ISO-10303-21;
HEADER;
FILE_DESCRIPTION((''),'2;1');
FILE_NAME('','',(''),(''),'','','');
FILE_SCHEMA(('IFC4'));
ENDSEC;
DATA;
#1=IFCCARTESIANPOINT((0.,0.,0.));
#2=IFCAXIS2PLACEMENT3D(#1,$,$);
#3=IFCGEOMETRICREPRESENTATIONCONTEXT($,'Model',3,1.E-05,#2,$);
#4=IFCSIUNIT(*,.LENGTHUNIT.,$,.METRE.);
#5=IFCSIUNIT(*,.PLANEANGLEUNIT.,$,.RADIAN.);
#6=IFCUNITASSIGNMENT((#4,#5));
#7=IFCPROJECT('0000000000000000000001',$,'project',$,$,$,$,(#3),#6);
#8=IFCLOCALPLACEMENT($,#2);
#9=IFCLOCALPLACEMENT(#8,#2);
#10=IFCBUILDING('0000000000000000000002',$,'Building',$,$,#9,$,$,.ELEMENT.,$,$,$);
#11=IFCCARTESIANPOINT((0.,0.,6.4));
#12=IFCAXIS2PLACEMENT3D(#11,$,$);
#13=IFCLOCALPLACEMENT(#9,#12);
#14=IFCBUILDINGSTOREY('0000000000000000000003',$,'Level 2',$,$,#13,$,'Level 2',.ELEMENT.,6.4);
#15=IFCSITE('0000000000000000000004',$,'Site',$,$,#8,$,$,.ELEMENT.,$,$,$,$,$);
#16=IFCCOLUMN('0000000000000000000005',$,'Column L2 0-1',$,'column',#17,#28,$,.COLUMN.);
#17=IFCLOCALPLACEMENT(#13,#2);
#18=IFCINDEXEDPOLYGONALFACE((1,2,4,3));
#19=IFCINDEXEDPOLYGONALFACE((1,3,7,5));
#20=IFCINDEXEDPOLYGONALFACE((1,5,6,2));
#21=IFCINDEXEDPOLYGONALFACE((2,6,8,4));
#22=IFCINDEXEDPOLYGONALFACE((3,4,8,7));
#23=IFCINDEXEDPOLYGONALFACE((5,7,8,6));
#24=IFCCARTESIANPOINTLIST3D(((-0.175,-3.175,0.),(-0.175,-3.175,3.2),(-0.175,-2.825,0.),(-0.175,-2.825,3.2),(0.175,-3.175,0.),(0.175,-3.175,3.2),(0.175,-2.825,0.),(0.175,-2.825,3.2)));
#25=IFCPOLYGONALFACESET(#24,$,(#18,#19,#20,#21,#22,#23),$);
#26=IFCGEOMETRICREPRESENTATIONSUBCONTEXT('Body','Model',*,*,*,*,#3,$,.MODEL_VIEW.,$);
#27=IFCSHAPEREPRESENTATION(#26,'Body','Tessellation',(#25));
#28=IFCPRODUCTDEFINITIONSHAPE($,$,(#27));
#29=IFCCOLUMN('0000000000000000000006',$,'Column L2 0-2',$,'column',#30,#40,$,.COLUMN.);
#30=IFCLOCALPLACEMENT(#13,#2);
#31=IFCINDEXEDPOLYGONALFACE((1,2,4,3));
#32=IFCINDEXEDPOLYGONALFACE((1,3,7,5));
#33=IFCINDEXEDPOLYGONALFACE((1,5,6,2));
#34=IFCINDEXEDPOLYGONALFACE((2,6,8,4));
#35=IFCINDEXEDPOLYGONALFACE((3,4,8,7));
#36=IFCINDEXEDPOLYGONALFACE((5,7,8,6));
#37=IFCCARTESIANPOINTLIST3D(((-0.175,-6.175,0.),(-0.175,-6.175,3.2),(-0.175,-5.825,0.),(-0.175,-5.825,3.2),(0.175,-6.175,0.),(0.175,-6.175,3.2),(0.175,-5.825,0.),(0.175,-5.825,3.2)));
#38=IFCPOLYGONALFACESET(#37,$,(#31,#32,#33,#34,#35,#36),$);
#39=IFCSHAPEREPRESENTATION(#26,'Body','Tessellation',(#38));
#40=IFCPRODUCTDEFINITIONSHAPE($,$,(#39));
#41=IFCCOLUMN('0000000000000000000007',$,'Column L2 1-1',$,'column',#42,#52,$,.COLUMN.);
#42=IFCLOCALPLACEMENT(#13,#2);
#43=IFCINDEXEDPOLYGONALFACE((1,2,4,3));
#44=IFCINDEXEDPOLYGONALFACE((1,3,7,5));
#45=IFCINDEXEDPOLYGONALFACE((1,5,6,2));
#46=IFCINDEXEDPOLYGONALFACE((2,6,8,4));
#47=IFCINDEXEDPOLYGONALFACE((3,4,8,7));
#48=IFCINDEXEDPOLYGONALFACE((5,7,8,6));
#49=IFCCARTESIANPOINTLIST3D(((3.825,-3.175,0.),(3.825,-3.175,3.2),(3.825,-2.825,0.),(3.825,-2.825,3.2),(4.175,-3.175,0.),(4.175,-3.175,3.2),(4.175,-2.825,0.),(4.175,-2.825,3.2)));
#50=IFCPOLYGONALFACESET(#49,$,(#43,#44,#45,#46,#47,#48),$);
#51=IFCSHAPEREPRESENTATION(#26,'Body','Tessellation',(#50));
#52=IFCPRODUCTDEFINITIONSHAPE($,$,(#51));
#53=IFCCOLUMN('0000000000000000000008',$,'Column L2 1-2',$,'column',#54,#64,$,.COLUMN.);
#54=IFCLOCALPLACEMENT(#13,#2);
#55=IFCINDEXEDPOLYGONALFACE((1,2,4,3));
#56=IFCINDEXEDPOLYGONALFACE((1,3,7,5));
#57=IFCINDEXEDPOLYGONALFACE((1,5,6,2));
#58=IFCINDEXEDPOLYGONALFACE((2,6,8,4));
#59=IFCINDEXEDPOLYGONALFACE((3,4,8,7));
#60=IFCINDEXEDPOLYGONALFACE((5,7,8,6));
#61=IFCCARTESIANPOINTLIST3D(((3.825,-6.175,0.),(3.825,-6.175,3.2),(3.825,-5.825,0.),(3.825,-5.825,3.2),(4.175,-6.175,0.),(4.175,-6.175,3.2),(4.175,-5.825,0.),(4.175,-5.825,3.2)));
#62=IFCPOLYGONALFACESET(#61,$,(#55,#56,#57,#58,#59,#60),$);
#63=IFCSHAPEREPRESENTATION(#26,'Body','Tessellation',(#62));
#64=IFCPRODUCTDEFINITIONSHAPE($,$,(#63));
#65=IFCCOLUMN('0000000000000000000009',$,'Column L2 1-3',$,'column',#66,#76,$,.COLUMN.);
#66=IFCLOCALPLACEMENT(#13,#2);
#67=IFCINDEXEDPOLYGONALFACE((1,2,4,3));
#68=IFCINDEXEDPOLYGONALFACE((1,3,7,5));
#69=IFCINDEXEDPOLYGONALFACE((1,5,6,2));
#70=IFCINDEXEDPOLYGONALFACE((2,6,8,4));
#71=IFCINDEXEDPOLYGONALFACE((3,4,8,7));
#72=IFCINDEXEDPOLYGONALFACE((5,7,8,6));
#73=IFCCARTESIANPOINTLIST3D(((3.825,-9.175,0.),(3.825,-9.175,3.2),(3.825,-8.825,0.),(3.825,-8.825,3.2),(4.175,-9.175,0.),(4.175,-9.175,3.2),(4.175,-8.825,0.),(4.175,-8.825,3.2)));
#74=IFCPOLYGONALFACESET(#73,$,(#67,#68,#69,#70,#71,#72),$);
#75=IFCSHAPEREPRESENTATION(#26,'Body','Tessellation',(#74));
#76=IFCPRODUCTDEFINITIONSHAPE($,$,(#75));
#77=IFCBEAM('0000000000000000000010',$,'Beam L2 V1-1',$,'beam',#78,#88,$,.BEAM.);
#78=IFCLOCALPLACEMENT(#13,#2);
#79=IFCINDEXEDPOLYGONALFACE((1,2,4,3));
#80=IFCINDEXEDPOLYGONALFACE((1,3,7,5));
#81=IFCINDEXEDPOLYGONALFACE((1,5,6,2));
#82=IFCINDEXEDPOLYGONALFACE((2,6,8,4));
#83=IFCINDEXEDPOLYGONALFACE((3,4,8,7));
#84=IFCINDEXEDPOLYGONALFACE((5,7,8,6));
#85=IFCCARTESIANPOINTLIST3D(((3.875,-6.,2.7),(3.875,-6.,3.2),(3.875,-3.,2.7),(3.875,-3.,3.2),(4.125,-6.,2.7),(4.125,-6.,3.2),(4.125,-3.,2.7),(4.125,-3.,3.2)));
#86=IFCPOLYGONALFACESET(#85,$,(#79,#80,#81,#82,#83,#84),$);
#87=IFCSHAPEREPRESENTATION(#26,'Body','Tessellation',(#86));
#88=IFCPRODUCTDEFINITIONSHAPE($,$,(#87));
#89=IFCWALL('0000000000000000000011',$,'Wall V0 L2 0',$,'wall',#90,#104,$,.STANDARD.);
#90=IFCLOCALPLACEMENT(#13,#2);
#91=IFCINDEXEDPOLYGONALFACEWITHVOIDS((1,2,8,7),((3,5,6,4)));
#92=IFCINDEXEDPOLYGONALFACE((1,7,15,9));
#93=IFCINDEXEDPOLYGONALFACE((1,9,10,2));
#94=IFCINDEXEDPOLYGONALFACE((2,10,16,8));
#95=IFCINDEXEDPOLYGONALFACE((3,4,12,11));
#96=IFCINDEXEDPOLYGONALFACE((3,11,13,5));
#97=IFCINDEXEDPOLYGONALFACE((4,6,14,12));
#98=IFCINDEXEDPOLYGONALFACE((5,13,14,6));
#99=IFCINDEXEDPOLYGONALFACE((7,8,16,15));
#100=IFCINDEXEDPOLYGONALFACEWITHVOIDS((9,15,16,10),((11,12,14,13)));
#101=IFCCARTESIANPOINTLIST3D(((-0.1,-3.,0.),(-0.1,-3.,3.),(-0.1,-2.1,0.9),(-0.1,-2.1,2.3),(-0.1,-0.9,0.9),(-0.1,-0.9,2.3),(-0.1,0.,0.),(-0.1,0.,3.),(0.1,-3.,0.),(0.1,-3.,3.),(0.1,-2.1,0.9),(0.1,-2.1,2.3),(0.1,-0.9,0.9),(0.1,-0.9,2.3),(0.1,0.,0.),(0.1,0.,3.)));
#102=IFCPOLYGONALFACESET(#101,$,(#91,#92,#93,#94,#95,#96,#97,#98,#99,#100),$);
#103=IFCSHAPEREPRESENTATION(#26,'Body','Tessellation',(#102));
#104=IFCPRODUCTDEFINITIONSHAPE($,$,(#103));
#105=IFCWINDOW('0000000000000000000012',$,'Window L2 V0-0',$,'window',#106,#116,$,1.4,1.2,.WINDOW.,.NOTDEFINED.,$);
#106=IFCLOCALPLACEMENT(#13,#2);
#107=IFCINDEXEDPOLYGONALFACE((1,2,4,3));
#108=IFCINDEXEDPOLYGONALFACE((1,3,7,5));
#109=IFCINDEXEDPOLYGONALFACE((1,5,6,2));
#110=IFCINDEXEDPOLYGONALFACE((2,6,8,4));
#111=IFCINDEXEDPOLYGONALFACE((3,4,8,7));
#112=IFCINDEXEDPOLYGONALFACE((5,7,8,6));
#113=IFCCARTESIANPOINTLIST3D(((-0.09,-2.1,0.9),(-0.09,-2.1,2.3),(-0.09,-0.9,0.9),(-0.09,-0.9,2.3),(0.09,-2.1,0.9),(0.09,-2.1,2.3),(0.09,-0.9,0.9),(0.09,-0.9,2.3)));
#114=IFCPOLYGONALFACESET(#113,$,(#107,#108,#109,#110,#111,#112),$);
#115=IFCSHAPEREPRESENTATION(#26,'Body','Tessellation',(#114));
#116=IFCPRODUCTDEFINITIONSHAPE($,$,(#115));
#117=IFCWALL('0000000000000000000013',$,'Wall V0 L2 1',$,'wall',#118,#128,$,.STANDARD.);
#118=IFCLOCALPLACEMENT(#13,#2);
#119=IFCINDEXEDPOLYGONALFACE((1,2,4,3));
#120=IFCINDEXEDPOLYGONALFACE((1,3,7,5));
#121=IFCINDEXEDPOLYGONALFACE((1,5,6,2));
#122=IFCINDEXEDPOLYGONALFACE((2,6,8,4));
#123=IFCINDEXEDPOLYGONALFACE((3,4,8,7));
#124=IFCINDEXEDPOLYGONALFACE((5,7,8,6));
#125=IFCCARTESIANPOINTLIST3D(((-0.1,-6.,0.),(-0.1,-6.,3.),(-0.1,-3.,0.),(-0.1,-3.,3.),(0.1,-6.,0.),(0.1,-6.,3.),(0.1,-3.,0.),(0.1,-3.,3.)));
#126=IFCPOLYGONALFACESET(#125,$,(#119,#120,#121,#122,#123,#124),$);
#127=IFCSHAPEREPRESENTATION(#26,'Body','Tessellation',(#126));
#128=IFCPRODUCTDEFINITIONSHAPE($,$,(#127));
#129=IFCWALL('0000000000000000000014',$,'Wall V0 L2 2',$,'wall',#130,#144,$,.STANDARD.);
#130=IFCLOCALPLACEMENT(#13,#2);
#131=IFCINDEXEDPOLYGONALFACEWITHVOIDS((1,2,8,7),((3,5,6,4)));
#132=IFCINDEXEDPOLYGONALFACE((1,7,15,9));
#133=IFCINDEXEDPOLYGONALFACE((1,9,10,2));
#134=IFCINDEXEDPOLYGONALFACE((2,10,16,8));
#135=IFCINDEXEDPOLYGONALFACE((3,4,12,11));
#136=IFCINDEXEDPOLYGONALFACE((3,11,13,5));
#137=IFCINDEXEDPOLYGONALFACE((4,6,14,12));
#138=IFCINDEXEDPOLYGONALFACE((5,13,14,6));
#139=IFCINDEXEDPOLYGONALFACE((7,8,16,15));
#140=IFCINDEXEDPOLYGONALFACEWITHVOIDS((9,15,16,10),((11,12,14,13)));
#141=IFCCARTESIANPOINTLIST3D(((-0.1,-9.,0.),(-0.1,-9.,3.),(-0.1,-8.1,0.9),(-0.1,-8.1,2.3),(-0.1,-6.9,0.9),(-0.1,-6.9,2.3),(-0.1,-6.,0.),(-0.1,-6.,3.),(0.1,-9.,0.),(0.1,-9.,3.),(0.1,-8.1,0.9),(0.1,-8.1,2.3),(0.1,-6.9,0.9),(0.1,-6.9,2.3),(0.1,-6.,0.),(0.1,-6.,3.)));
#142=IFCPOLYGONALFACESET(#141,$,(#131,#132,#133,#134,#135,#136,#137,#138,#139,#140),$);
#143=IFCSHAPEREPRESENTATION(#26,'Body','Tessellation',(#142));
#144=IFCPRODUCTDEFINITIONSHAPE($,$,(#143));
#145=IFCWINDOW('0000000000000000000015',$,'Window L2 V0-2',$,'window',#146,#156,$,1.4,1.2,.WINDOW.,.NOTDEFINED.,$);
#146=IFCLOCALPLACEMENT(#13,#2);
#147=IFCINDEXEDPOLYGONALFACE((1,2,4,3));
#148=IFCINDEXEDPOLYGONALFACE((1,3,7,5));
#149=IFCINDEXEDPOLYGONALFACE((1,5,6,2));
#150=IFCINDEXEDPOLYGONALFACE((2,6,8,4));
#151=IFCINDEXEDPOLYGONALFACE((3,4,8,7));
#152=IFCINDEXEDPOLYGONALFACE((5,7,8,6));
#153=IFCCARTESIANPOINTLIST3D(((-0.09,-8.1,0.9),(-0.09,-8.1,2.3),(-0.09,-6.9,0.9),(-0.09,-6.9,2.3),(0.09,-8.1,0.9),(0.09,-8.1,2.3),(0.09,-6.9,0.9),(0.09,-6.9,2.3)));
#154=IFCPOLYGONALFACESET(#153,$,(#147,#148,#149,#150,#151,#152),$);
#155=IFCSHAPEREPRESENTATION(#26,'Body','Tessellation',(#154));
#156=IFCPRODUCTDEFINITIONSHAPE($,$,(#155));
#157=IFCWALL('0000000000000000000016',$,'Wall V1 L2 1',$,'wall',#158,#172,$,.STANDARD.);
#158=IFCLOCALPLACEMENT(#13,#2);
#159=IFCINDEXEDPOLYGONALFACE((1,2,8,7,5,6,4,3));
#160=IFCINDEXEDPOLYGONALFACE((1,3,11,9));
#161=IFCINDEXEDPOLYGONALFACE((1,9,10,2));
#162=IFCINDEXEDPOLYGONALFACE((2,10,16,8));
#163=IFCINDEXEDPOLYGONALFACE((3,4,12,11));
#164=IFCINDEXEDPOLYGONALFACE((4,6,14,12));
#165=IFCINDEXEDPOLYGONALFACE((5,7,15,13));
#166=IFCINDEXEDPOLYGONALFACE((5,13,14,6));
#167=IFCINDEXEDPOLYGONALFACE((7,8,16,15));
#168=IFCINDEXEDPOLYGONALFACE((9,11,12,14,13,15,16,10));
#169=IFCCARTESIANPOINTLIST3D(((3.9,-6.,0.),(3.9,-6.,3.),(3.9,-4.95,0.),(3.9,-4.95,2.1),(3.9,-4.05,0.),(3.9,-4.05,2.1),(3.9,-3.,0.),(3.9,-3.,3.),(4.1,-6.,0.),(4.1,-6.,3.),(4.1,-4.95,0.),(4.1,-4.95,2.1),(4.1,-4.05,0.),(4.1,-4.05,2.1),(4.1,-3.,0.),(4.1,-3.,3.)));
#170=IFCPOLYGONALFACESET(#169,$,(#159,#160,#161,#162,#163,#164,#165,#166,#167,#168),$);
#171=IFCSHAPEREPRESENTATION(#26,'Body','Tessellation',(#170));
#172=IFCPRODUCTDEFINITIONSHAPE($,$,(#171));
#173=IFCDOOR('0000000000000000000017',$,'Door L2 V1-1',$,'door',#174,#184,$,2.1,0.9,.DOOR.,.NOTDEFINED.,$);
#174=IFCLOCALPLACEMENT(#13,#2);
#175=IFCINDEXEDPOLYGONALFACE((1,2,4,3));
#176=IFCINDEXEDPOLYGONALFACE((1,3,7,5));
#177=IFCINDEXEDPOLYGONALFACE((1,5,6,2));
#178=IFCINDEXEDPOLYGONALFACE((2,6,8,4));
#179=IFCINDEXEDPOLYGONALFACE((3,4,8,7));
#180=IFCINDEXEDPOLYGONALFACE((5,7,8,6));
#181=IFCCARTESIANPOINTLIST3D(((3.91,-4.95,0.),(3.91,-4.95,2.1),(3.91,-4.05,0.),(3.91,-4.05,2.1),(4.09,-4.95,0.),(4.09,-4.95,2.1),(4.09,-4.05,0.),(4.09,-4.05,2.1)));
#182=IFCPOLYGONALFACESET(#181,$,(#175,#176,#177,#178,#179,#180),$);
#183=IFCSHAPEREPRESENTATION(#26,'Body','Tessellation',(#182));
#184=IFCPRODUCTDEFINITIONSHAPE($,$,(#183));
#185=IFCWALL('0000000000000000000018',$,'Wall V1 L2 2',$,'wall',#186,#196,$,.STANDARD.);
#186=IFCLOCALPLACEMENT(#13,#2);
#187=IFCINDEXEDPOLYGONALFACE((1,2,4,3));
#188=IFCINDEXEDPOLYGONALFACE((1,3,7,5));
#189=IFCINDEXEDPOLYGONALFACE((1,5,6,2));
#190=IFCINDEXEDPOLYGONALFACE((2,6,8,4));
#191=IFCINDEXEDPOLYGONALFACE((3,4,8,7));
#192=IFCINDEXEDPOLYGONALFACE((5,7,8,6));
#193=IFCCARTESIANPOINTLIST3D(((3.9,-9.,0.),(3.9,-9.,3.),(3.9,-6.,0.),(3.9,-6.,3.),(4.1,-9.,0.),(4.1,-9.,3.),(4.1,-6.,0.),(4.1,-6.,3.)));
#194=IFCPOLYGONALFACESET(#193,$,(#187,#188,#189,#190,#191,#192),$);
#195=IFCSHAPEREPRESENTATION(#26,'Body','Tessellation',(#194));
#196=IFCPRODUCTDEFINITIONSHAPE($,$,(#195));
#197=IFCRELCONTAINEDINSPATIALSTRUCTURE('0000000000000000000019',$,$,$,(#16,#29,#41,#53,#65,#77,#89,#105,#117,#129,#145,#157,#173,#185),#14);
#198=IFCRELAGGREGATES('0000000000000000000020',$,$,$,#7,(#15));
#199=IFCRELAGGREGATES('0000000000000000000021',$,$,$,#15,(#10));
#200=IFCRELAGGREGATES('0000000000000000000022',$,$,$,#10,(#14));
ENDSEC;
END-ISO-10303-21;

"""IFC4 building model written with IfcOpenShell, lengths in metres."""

from ifc_helpers import new_model, si_unit, frame, frame_2d, origin, origin_2d, place, context, subcontext, project, spatial, rectangle, extrude, element, fill, save


model = new_model("IFC4")

# Units and contexts
model_context = context("Model", 3, precision=1e-05, world=origin())
body_context = subcontext(model_context, "Body", "Model", "MODEL_VIEW")
ifc_project = project(units=[si_unit("LENGTHUNIT", "METRE"), si_unit("PLANEANGLEUNIT", "RADIAN")], contexts=[model_context])

# Site, building, storey
site_placement = place(None, origin())
site = spatial("IfcSite", under=ifc_project, at=site_placement, Name="Site", CompositionType="ELEMENT")
building_placement = place(site_placement, origin())
building = spatial("IfcBuilding", under=site, at=building_placement, Name="Building", CompositionType="ELEMENT")
storey_placement = place(building_placement, frame((0.0, 0.0, 6.4)))
storey = spatial("IfcBuildingStorey", under=building, at=storey_placement, Name="Level 2", LongName="Level 2", CompositionType="ELEMENT", Elevation=6.4)

# Columns
for number, where, name in (
    (1, (0.0, -3.0, 0.0), "Column L2 0-1"),
    (2, (0.0, -6.0, 0.0), "Column L2 0-2"),
    (3, (4.0, -3.0, 0.0), "Column L2 1-1"),
    (4, (4.0, -6.0, 0.0), "Column L2 1-2"),
    (5, (4.0, -9.0, 0.0), "Column L2 1-3"),
):
    element("IfcColumn", number, at=place(storey_placement, frame(where)), inside=storey, Name=name, ObjectType="column", PredefinedType="COLUMN", context=body_context, shape_type="SweptSolid", body=[
        extrude(rectangle(XDim=0.35, YDim=0.35, at=origin_2d()), origin(), (0.0, 0.0, 1.0), 3.2),
    ])

# Beam
beam_placement = place(storey_placement, frame((4.0, -3.0, 2.95), z_axis=(0.0, -1.0, 0.0), x_axis=(0.0, 0.0, 1.0)))
element("IfcBeam", 6, at=beam_placement, inside=storey, Name="Beam L2 V1-1", ObjectType="beam", PredefinedType="BEAM", context=body_context, shape_type="SweptSolid", body=[
    extrude(rectangle(XDim=0.5, YDim=0.25, at=origin_2d()), origin(), (0.0, 0.0, 1.0), 3.0),
])

# Wall, opening, window
wall_1_placement = place(storey_placement, frame((0.0, 0.0, 0.0), z_axis=(0.0, 0.0, 1.0), x_axis=(0.0, -1.0, 0.0)))
wall_1 = element("IfcWall", 7, at=wall_1_placement, inside=storey, Name="Wall V0 L2 0", ObjectType="wall", PredefinedType="STANDARD", context=body_context, shape_type="SweptSolid", body=[
    extrude(rectangle(XDim=3.0, YDim=0.2, at=frame_2d((1.5, 0.0))), origin(), (0.0, 0.0, 1.0), 3.0),
])
opening_1_placement = place(storey_placement, frame((0.0, -1.5, 0.9), z_axis=(0.0, 0.0, 1.0), x_axis=(0.0, -1.0, 0.0)))
opening_1 = element("IfcOpeningElement", 8, at=opening_1_placement, cuts=wall_1, ObjectType="Opening", PredefinedType="OPENING", context=body_context, shape_type="SweptSolid", body=[
    extrude(rectangle(XDim=1.2, YDim=0.22, at=origin_2d()), origin(), (0.0, 0.0, 1.0), 1.4),
])
window_1_placement = place(storey_placement, frame((0.0, -1.5, 0.9), z_axis=(0.0, 0.0, 1.0), x_axis=(0.0, -1.0, 0.0)))
window_1 = element("IfcWindow", 9, at=window_1_placement, inside=storey, Name="Window L2 V0-0", ObjectType="window", OverallHeight=1.4, OverallWidth=1.2, PartitioningType="NOTDEFINED", PredefinedType="WINDOW", context=body_context, shape_type="SweptSolid", body=[
    extrude(rectangle(XDim=1.2, YDim=0.18, at=origin_2d()), origin(), (0.0, 0.0, 1.0), 1.4),
])
fill(opening_1, window_1)

# Wall
wall_2_placement = place(storey_placement, frame((0.0, -3.0, 0.0), z_axis=(0.0, 0.0, 1.0), x_axis=(0.0, -1.0, 0.0)))
element("IfcWall", 10, at=wall_2_placement, inside=storey, Name="Wall V0 L2 1", ObjectType="wall", PredefinedType="STANDARD", context=body_context, shape_type="SweptSolid", body=[
    extrude(rectangle(XDim=3.0, YDim=0.2, at=frame_2d((1.5, 0.0))), origin(), (0.0, 0.0, 1.0), 3.0),
])

# Wall, opening, window
wall_3_placement = place(storey_placement, frame((0.0, -6.0, 0.0), z_axis=(0.0, 0.0, 1.0), x_axis=(0.0, -1.0, 0.0)))
wall_3 = element("IfcWall", 11, at=wall_3_placement, inside=storey, Name="Wall V0 L2 2", ObjectType="wall", PredefinedType="STANDARD", context=body_context, shape_type="SweptSolid", body=[
    extrude(rectangle(XDim=3.0, YDim=0.2, at=frame_2d((1.5, 0.0))), origin(), (0.0, 0.0, 1.0), 3.0),
])
opening_2_placement = place(storey_placement, frame((0.0, -7.5, 0.9), z_axis=(0.0, 0.0, 1.0), x_axis=(0.0, -1.0, 0.0)))
opening_2 = element("IfcOpeningElement", 12, at=opening_2_placement, cuts=wall_3, ObjectType="Opening", PredefinedType="OPENING", context=body_context, shape_type="SweptSolid", body=[
    extrude(rectangle(XDim=1.2, YDim=0.22, at=origin_2d()), origin(), (0.0, 0.0, 1.0), 1.4),
])
window_2_placement = place(storey_placement, frame((0.0, -7.5, 0.9), z_axis=(0.0, 0.0, 1.0), x_axis=(0.0, -1.0, 0.0)))
window_2 = element("IfcWindow", 13, at=window_2_placement, inside=storey, Name="Window L2 V0-2", ObjectType="window", OverallHeight=1.4, OverallWidth=1.2, PartitioningType="NOTDEFINED", PredefinedType="WINDOW", context=body_context, shape_type="SweptSolid", body=[
    extrude(rectangle(XDim=1.2, YDim=0.18, at=origin_2d()), origin(), (0.0, 0.0, 1.0), 1.4),
])
fill(opening_2, window_2)

# Wall, opening, door
wall_4_placement = place(storey_placement, frame((4.0, -3.0, 0.0), z_axis=(0.0, 0.0, 1.0), x_axis=(0.0, -1.0, 0.0)))
wall_4 = element("IfcWall", 14, at=wall_4_placement, inside=storey, Name="Wall V1 L2 1", ObjectType="wall", PredefinedType="STANDARD", context=body_context, shape_type="SweptSolid", body=[
    extrude(rectangle(XDim=3.0, YDim=0.2, at=frame_2d((1.5, 0.0))), origin(), (0.0, 0.0, 1.0), 3.0),
])
opening_3_placement = place(storey_placement, frame((4.0, -4.5, 0.0), z_axis=(0.0, 0.0, 1.0), x_axis=(0.0, -1.0, 0.0)))
opening_3 = element("IfcOpeningElement", 15, at=opening_3_placement, cuts=wall_4, ObjectType="Opening", PredefinedType="OPENING", context=body_context, shape_type="SweptSolid", body=[
    extrude(rectangle(XDim=0.9, YDim=0.22, at=origin_2d()), origin(), (0.0, 0.0, 1.0), 2.1),
])
door_placement = place(storey_placement, frame((4.0, -4.5, 0.0), z_axis=(0.0, 0.0, 1.0), x_axis=(0.0, -1.0, 0.0)))
door = element("IfcDoor", 16, at=door_placement, inside=storey, Name="Door L2 V1-1", ObjectType="door", OperationType="NOTDEFINED", OverallHeight=2.1, OverallWidth=0.9, PredefinedType="DOOR", context=body_context, shape_type="SweptSolid", body=[
    extrude(rectangle(XDim=0.9, YDim=0.18, at=origin_2d()), origin(), (0.0, 0.0, 1.0), 2.1),
])
fill(opening_3, door)

# Wall
wall_5_placement = place(storey_placement, frame((4.0, -6.0, 0.0), z_axis=(0.0, 0.0, 1.0), x_axis=(0.0, -1.0, 0.0)))
element("IfcWall", 17, at=wall_5_placement, inside=storey, Name="Wall V1 L2 2", ObjectType="wall", PredefinedType="STANDARD", context=body_context, shape_type="SweptSolid", body=[
    extrude(rectangle(XDim=3.0, YDim=0.2, at=frame_2d((1.5, 0.0))), origin(), (0.0, 0.0, 1.0), 3.0),
])

save(model, "model.ifc")
